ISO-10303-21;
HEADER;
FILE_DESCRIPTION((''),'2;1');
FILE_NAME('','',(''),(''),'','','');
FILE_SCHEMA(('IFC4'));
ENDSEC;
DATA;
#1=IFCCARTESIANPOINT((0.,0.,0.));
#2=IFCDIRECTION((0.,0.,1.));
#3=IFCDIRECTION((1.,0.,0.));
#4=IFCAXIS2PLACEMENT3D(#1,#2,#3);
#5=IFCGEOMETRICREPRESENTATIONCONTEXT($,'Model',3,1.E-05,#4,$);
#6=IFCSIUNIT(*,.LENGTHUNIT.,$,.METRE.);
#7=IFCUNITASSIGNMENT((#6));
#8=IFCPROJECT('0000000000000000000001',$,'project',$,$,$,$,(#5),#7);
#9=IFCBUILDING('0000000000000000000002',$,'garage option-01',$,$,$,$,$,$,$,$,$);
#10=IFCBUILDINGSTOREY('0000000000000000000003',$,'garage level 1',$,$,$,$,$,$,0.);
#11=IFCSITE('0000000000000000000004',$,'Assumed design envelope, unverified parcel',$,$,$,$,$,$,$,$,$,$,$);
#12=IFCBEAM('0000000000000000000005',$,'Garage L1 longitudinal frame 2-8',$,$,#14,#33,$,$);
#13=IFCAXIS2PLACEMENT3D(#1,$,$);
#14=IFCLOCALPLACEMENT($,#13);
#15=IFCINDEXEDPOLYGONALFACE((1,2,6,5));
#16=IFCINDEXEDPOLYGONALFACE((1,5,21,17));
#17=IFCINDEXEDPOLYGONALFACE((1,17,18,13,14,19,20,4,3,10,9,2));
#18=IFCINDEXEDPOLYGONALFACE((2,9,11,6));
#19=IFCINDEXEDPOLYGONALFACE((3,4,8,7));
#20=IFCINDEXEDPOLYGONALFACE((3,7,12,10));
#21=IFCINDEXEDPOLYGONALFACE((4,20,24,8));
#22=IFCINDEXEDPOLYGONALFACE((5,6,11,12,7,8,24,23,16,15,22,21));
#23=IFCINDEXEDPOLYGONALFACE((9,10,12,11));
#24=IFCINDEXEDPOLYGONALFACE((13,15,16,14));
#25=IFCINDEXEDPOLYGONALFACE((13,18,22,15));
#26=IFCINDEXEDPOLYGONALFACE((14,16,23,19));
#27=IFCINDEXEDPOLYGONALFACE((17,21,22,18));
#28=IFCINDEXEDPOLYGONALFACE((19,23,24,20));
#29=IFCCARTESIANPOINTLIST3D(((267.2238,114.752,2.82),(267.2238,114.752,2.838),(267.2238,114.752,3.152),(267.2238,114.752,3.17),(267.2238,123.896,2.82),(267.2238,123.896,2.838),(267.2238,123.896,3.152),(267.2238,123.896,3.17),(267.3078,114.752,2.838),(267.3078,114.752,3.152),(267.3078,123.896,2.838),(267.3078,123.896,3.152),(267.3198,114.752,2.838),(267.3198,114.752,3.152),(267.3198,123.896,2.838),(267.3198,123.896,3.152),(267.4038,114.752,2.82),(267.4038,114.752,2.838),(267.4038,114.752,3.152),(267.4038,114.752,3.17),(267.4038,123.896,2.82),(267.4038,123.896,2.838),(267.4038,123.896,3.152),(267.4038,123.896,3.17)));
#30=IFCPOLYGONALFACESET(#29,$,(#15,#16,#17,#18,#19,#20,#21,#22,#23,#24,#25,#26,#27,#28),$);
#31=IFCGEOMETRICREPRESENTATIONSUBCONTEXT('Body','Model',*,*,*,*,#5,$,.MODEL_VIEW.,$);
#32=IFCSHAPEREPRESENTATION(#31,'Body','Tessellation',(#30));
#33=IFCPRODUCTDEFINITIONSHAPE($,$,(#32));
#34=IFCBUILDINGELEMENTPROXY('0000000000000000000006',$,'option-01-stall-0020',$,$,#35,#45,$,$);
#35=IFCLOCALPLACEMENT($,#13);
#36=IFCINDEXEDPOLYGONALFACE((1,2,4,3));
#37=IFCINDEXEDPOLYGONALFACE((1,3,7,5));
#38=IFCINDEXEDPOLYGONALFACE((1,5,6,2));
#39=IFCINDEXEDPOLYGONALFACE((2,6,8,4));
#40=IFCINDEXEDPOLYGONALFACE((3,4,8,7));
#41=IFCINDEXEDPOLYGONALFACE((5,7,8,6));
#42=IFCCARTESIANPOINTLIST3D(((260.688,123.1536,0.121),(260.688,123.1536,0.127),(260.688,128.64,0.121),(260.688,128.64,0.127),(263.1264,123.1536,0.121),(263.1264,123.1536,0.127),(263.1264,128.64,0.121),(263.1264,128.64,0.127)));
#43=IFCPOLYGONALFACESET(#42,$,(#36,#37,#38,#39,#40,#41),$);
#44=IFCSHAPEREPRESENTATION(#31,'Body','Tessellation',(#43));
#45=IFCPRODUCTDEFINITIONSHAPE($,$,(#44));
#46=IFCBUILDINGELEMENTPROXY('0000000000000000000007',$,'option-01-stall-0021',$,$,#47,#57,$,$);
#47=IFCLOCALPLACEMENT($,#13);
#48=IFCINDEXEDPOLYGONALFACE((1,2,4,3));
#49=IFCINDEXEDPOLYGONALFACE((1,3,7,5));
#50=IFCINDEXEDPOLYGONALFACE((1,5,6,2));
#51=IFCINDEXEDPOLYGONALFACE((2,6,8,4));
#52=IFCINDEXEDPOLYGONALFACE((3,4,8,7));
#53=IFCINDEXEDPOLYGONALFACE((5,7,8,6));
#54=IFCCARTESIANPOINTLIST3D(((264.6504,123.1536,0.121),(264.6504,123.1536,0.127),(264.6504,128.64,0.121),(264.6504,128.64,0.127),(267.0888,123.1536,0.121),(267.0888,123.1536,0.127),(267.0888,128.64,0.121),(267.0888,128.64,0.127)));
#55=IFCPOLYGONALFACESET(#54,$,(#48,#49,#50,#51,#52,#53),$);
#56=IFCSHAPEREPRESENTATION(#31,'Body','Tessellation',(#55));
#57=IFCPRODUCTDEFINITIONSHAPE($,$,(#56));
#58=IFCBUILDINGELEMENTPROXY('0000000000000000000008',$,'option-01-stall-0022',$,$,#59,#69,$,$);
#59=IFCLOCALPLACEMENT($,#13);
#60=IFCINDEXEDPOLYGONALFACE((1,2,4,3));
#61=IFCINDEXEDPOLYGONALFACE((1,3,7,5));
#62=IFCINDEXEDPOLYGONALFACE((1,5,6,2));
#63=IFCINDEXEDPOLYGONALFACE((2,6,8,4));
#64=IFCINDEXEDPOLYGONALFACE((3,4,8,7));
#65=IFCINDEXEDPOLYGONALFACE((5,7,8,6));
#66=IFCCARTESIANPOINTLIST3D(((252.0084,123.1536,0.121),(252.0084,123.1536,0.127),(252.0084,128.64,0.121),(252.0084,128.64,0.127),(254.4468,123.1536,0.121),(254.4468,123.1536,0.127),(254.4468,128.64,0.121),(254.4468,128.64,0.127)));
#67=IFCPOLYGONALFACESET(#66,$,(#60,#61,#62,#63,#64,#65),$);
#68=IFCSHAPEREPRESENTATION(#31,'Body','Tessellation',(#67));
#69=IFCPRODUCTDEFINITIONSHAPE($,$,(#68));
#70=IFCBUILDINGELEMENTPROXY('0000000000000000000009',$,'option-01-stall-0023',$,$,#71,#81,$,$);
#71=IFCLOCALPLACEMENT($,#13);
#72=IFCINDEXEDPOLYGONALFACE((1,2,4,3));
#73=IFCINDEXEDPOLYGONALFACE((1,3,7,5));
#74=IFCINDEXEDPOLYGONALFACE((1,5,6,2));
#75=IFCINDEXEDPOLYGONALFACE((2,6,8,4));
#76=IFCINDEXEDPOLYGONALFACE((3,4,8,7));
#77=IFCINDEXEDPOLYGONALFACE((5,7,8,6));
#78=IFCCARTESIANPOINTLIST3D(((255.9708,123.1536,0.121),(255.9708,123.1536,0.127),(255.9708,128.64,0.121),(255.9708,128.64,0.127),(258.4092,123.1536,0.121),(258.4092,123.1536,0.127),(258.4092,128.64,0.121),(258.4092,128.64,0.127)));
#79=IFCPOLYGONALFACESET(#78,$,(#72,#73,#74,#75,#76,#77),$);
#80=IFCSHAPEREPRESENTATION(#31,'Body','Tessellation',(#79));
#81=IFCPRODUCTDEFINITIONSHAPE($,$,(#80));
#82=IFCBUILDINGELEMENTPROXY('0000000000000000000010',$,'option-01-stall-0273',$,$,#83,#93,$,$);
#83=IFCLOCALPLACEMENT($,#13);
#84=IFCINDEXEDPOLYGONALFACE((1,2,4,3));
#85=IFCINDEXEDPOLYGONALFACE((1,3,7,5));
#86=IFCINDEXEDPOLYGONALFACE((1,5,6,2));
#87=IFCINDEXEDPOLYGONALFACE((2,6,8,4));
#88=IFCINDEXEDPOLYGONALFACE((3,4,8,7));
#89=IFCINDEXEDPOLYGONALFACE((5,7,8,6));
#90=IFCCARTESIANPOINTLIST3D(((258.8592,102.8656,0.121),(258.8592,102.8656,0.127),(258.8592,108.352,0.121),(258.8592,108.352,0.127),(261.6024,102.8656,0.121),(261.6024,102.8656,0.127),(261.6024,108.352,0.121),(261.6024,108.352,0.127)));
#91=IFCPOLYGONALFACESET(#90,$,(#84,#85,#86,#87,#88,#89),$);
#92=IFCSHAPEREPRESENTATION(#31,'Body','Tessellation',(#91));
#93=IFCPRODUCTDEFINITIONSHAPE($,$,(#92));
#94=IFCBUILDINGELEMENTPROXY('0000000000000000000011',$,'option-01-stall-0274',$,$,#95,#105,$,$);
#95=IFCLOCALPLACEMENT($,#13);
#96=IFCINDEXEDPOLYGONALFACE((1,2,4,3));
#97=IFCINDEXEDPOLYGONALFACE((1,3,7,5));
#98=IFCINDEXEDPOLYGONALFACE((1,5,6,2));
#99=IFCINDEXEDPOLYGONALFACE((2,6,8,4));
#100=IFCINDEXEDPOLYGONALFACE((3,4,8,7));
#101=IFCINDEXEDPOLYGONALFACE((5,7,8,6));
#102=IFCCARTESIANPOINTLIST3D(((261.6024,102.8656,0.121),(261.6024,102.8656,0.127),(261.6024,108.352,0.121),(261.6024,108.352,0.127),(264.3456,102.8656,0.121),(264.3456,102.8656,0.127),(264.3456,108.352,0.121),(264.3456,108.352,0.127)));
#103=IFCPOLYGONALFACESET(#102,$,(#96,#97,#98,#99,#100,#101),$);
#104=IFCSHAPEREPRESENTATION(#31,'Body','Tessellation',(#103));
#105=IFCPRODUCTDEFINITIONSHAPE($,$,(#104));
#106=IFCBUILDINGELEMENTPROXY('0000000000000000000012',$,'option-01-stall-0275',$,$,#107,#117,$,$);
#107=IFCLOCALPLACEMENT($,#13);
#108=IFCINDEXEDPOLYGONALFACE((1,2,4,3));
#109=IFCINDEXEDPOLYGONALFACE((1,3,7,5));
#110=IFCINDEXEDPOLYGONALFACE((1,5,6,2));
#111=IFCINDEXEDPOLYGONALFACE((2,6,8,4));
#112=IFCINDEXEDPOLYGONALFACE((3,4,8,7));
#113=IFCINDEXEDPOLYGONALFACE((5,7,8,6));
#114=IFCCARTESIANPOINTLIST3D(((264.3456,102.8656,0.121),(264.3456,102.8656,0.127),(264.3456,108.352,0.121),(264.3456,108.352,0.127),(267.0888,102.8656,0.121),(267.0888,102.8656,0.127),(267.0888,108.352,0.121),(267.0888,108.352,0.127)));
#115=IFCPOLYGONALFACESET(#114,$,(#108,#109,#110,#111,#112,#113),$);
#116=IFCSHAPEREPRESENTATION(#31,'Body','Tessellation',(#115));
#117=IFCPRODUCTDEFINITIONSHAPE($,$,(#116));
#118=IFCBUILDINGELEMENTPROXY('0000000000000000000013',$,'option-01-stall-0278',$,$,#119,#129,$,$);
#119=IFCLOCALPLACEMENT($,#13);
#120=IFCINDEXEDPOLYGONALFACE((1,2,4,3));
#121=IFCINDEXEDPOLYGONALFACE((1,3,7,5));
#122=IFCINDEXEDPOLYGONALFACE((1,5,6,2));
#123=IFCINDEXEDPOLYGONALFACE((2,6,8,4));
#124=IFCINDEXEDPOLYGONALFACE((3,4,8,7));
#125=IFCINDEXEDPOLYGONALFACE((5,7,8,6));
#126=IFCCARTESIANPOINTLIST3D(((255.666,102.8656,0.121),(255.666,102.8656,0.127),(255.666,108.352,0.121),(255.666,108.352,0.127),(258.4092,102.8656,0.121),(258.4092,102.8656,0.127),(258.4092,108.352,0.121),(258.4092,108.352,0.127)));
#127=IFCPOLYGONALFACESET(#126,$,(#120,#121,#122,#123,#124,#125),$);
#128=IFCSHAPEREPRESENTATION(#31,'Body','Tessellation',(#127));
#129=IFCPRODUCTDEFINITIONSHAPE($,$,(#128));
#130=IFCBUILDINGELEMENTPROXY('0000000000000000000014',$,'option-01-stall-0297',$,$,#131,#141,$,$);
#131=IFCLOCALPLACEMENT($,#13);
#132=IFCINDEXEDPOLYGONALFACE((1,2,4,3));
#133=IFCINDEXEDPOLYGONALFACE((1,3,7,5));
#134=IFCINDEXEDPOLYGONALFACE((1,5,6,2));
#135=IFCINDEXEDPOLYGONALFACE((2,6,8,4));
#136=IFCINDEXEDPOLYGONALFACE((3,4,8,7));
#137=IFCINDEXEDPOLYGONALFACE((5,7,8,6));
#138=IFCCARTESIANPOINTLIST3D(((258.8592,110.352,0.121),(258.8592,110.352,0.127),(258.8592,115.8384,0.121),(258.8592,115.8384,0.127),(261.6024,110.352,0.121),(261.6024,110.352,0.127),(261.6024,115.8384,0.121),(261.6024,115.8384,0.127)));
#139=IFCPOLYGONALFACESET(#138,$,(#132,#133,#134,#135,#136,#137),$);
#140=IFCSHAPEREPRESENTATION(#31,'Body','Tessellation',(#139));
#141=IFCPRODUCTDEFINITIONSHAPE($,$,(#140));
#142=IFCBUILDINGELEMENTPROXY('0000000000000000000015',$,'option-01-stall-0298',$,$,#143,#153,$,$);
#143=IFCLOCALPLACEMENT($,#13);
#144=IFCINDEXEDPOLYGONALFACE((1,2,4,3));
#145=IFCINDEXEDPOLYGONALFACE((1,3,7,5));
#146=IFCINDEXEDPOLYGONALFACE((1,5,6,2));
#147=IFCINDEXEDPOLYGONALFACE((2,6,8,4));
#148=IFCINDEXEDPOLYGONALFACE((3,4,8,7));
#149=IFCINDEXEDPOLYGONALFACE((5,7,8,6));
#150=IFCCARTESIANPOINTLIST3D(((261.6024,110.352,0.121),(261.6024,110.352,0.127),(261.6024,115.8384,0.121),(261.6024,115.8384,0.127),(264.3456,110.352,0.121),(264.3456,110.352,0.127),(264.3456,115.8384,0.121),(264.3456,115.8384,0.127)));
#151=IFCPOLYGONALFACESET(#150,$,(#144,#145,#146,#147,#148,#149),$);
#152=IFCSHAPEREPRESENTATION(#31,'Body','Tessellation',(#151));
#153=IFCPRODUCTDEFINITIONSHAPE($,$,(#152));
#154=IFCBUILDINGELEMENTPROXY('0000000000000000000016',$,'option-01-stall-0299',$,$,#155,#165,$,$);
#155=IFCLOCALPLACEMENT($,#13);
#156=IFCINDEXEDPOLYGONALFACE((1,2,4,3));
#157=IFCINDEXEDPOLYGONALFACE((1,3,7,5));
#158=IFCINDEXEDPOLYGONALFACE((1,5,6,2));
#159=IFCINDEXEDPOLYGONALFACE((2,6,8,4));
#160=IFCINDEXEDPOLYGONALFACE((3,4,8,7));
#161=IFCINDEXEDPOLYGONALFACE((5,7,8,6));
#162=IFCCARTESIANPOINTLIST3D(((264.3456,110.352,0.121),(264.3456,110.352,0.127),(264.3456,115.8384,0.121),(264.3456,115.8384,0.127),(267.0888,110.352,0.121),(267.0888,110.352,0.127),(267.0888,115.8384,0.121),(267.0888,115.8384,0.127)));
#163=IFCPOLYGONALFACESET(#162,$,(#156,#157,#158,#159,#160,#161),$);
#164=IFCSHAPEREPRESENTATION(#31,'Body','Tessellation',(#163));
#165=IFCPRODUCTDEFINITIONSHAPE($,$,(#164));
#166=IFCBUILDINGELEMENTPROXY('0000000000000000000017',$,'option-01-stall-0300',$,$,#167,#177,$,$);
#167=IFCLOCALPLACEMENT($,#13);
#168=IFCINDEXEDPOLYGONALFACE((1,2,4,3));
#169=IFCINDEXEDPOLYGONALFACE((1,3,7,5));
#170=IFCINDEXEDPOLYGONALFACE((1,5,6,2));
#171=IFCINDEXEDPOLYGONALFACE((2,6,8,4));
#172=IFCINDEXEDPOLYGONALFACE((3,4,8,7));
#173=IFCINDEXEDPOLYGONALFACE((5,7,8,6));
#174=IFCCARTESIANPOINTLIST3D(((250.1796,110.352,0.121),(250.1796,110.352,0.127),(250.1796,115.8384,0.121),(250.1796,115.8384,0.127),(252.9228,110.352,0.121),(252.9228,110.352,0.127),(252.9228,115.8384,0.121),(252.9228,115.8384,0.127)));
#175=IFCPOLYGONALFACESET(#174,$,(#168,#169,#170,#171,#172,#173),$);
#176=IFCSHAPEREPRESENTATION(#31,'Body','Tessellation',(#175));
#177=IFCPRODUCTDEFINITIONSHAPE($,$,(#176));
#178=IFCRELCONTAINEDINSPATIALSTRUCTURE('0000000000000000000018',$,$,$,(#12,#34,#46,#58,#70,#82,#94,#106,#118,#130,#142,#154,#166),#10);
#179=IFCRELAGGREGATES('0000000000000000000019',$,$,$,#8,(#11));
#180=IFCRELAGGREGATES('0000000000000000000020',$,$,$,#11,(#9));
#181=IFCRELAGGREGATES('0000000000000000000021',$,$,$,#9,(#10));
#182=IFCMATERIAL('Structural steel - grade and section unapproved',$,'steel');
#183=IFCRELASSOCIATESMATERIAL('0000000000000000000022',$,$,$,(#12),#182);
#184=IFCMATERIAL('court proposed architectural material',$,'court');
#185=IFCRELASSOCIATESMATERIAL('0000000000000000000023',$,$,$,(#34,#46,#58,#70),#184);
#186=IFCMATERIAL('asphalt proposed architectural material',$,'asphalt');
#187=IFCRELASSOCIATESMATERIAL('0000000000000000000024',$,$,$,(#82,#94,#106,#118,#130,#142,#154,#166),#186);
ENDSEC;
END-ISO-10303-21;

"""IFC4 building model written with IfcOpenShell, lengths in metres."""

from ifc_helpers import new_model, si_unit, frame, origin_with_axes, place, context, subcontext, project, spatial, rectangle, i_section, extrude, material, element, save


model = new_model("IFC4")

# Units and contexts
model_context = context("Model", 3, precision=1e-05, world=origin_with_axes())
body_context = subcontext(model_context, "Body", "Model", "MODEL_VIEW")
ifc_project = project(units=[si_unit("LENGTHUNIT", "METRE")], contexts=[model_context])

# Site, building, storey
site = spatial("IfcSite", under=ifc_project, Name="Assumed design envelope, unverified parcel")
building = spatial("IfcBuilding", under=site, Name="garage option-01")
storey = spatial("IfcBuildingStorey", under=building, Name="garage level 1", Elevation=0.0)

# Beam
ifc_material_1 = material(Name="Structural steel - grade and section unapproved", Category="steel")
for number, where, z_axis, x_axis, name in (
    (1, (267.3138, 114.752, 2.995), (0.0, 1.0, 0.0), (-1.0, 0.0, 0.0), "Garage L1 longitudinal frame 2-8"),
):
    element("IfcBeam", number, at=place(None, frame(where, z_axis=z_axis, x_axis=x_axis)), inside=storey, material=ifc_material_1, Name=name, context=body_context, shape_type="SweptSolid", body=[
        extrude(i_section(OverallWidth=0.18, OverallDepth=0.35, WebThickness=0.012, FlangeThickness=0.018, FilletRadius=0.0), origin_with_axes(), (0.0, 0.0, 1.0), 9.144),
    ])

# Building element proxies
ifc_material_2 = material(Name="court proposed architectural material", Category="court")
for number, where, z_axis, x_axis, name in (
    (2, (261.9072, 125.8968, 0.121), (0.0, 0.0, 1.0), (1.0, 0.0, 0.0), "option-01-stall-0020"),
    (3, (265.8696, 125.8968, 0.121), (0.0, 0.0, 1.0), (1.0, 0.0, 0.0), "option-01-stall-0021"),
    (4, (253.2276, 125.8968, 0.121), (0.0, 0.0, 1.0), (1.0, 0.0, 0.0), "option-01-stall-0022"),
    (5, (257.19, 125.8968, 0.121), (0.0, 0.0, 1.0), (1.0, 0.0, 0.0), "option-01-stall-0023"),
):
    element("IfcBuildingElementProxy", number, at=place(None, frame(where, z_axis=z_axis, x_axis=x_axis)), inside=storey, material=ifc_material_2, Name=name, context=body_context, shape_type="SweptSolid", body=[
        extrude(rectangle(XDim=2.4384, YDim=5.4864), origin_with_axes(), (0.0, 0.0, 1.0), 0.006),
    ])
ifc_material_3 = material(Name="asphalt proposed architectural material", Category="asphalt")
for number, where, z_axis, x_axis, name in (
    (6, (260.2308, 105.6088, 0.121), (0.0, 0.0, 1.0), (1.0, 0.0, 0.0), "option-01-stall-0273"),
    (7, (262.974, 105.6088, 0.121), (0.0, 0.0, 1.0), (1.0, 0.0, 0.0), "option-01-stall-0274"),
    (8, (265.7172, 105.6088, 0.121), (0.0, 0.0, 1.0), (1.0, 0.0, 0.0), "option-01-stall-0275"),
    (9, (257.0376, 105.6088, 0.121), (0.0, 0.0, 1.0), (1.0, 0.0, 0.0), "option-01-stall-0278"),
    (10, (260.2308, 113.0952, 0.121), (0.0, 0.0, 1.0), (1.0, 0.0, 0.0), "option-01-stall-0297"),
    (11, (262.974, 113.0952, 0.121), (0.0, 0.0, 1.0), (1.0, 0.0, 0.0), "option-01-stall-0298"),
    (12, (265.7172, 113.0952, 0.121), (0.0, 0.0, 1.0), (1.0, 0.0, 0.0), "option-01-stall-0299"),
    (13, (251.5512, 113.0952, 0.121), (0.0, 0.0, 1.0), (1.0, 0.0, 0.0), "option-01-stall-0300"),
):
    element("IfcBuildingElementProxy", number, at=place(None, frame(where, z_axis=z_axis, x_axis=x_axis)), inside=storey, material=ifc_material_3, Name=name, context=body_context, shape_type="SweptSolid", body=[
        extrude(rectangle(XDim=2.7432, YDim=5.4864), origin_with_axes(), (0.0, 0.0, 1.0), 0.006),
    ])

save(model, "model.ifc")
